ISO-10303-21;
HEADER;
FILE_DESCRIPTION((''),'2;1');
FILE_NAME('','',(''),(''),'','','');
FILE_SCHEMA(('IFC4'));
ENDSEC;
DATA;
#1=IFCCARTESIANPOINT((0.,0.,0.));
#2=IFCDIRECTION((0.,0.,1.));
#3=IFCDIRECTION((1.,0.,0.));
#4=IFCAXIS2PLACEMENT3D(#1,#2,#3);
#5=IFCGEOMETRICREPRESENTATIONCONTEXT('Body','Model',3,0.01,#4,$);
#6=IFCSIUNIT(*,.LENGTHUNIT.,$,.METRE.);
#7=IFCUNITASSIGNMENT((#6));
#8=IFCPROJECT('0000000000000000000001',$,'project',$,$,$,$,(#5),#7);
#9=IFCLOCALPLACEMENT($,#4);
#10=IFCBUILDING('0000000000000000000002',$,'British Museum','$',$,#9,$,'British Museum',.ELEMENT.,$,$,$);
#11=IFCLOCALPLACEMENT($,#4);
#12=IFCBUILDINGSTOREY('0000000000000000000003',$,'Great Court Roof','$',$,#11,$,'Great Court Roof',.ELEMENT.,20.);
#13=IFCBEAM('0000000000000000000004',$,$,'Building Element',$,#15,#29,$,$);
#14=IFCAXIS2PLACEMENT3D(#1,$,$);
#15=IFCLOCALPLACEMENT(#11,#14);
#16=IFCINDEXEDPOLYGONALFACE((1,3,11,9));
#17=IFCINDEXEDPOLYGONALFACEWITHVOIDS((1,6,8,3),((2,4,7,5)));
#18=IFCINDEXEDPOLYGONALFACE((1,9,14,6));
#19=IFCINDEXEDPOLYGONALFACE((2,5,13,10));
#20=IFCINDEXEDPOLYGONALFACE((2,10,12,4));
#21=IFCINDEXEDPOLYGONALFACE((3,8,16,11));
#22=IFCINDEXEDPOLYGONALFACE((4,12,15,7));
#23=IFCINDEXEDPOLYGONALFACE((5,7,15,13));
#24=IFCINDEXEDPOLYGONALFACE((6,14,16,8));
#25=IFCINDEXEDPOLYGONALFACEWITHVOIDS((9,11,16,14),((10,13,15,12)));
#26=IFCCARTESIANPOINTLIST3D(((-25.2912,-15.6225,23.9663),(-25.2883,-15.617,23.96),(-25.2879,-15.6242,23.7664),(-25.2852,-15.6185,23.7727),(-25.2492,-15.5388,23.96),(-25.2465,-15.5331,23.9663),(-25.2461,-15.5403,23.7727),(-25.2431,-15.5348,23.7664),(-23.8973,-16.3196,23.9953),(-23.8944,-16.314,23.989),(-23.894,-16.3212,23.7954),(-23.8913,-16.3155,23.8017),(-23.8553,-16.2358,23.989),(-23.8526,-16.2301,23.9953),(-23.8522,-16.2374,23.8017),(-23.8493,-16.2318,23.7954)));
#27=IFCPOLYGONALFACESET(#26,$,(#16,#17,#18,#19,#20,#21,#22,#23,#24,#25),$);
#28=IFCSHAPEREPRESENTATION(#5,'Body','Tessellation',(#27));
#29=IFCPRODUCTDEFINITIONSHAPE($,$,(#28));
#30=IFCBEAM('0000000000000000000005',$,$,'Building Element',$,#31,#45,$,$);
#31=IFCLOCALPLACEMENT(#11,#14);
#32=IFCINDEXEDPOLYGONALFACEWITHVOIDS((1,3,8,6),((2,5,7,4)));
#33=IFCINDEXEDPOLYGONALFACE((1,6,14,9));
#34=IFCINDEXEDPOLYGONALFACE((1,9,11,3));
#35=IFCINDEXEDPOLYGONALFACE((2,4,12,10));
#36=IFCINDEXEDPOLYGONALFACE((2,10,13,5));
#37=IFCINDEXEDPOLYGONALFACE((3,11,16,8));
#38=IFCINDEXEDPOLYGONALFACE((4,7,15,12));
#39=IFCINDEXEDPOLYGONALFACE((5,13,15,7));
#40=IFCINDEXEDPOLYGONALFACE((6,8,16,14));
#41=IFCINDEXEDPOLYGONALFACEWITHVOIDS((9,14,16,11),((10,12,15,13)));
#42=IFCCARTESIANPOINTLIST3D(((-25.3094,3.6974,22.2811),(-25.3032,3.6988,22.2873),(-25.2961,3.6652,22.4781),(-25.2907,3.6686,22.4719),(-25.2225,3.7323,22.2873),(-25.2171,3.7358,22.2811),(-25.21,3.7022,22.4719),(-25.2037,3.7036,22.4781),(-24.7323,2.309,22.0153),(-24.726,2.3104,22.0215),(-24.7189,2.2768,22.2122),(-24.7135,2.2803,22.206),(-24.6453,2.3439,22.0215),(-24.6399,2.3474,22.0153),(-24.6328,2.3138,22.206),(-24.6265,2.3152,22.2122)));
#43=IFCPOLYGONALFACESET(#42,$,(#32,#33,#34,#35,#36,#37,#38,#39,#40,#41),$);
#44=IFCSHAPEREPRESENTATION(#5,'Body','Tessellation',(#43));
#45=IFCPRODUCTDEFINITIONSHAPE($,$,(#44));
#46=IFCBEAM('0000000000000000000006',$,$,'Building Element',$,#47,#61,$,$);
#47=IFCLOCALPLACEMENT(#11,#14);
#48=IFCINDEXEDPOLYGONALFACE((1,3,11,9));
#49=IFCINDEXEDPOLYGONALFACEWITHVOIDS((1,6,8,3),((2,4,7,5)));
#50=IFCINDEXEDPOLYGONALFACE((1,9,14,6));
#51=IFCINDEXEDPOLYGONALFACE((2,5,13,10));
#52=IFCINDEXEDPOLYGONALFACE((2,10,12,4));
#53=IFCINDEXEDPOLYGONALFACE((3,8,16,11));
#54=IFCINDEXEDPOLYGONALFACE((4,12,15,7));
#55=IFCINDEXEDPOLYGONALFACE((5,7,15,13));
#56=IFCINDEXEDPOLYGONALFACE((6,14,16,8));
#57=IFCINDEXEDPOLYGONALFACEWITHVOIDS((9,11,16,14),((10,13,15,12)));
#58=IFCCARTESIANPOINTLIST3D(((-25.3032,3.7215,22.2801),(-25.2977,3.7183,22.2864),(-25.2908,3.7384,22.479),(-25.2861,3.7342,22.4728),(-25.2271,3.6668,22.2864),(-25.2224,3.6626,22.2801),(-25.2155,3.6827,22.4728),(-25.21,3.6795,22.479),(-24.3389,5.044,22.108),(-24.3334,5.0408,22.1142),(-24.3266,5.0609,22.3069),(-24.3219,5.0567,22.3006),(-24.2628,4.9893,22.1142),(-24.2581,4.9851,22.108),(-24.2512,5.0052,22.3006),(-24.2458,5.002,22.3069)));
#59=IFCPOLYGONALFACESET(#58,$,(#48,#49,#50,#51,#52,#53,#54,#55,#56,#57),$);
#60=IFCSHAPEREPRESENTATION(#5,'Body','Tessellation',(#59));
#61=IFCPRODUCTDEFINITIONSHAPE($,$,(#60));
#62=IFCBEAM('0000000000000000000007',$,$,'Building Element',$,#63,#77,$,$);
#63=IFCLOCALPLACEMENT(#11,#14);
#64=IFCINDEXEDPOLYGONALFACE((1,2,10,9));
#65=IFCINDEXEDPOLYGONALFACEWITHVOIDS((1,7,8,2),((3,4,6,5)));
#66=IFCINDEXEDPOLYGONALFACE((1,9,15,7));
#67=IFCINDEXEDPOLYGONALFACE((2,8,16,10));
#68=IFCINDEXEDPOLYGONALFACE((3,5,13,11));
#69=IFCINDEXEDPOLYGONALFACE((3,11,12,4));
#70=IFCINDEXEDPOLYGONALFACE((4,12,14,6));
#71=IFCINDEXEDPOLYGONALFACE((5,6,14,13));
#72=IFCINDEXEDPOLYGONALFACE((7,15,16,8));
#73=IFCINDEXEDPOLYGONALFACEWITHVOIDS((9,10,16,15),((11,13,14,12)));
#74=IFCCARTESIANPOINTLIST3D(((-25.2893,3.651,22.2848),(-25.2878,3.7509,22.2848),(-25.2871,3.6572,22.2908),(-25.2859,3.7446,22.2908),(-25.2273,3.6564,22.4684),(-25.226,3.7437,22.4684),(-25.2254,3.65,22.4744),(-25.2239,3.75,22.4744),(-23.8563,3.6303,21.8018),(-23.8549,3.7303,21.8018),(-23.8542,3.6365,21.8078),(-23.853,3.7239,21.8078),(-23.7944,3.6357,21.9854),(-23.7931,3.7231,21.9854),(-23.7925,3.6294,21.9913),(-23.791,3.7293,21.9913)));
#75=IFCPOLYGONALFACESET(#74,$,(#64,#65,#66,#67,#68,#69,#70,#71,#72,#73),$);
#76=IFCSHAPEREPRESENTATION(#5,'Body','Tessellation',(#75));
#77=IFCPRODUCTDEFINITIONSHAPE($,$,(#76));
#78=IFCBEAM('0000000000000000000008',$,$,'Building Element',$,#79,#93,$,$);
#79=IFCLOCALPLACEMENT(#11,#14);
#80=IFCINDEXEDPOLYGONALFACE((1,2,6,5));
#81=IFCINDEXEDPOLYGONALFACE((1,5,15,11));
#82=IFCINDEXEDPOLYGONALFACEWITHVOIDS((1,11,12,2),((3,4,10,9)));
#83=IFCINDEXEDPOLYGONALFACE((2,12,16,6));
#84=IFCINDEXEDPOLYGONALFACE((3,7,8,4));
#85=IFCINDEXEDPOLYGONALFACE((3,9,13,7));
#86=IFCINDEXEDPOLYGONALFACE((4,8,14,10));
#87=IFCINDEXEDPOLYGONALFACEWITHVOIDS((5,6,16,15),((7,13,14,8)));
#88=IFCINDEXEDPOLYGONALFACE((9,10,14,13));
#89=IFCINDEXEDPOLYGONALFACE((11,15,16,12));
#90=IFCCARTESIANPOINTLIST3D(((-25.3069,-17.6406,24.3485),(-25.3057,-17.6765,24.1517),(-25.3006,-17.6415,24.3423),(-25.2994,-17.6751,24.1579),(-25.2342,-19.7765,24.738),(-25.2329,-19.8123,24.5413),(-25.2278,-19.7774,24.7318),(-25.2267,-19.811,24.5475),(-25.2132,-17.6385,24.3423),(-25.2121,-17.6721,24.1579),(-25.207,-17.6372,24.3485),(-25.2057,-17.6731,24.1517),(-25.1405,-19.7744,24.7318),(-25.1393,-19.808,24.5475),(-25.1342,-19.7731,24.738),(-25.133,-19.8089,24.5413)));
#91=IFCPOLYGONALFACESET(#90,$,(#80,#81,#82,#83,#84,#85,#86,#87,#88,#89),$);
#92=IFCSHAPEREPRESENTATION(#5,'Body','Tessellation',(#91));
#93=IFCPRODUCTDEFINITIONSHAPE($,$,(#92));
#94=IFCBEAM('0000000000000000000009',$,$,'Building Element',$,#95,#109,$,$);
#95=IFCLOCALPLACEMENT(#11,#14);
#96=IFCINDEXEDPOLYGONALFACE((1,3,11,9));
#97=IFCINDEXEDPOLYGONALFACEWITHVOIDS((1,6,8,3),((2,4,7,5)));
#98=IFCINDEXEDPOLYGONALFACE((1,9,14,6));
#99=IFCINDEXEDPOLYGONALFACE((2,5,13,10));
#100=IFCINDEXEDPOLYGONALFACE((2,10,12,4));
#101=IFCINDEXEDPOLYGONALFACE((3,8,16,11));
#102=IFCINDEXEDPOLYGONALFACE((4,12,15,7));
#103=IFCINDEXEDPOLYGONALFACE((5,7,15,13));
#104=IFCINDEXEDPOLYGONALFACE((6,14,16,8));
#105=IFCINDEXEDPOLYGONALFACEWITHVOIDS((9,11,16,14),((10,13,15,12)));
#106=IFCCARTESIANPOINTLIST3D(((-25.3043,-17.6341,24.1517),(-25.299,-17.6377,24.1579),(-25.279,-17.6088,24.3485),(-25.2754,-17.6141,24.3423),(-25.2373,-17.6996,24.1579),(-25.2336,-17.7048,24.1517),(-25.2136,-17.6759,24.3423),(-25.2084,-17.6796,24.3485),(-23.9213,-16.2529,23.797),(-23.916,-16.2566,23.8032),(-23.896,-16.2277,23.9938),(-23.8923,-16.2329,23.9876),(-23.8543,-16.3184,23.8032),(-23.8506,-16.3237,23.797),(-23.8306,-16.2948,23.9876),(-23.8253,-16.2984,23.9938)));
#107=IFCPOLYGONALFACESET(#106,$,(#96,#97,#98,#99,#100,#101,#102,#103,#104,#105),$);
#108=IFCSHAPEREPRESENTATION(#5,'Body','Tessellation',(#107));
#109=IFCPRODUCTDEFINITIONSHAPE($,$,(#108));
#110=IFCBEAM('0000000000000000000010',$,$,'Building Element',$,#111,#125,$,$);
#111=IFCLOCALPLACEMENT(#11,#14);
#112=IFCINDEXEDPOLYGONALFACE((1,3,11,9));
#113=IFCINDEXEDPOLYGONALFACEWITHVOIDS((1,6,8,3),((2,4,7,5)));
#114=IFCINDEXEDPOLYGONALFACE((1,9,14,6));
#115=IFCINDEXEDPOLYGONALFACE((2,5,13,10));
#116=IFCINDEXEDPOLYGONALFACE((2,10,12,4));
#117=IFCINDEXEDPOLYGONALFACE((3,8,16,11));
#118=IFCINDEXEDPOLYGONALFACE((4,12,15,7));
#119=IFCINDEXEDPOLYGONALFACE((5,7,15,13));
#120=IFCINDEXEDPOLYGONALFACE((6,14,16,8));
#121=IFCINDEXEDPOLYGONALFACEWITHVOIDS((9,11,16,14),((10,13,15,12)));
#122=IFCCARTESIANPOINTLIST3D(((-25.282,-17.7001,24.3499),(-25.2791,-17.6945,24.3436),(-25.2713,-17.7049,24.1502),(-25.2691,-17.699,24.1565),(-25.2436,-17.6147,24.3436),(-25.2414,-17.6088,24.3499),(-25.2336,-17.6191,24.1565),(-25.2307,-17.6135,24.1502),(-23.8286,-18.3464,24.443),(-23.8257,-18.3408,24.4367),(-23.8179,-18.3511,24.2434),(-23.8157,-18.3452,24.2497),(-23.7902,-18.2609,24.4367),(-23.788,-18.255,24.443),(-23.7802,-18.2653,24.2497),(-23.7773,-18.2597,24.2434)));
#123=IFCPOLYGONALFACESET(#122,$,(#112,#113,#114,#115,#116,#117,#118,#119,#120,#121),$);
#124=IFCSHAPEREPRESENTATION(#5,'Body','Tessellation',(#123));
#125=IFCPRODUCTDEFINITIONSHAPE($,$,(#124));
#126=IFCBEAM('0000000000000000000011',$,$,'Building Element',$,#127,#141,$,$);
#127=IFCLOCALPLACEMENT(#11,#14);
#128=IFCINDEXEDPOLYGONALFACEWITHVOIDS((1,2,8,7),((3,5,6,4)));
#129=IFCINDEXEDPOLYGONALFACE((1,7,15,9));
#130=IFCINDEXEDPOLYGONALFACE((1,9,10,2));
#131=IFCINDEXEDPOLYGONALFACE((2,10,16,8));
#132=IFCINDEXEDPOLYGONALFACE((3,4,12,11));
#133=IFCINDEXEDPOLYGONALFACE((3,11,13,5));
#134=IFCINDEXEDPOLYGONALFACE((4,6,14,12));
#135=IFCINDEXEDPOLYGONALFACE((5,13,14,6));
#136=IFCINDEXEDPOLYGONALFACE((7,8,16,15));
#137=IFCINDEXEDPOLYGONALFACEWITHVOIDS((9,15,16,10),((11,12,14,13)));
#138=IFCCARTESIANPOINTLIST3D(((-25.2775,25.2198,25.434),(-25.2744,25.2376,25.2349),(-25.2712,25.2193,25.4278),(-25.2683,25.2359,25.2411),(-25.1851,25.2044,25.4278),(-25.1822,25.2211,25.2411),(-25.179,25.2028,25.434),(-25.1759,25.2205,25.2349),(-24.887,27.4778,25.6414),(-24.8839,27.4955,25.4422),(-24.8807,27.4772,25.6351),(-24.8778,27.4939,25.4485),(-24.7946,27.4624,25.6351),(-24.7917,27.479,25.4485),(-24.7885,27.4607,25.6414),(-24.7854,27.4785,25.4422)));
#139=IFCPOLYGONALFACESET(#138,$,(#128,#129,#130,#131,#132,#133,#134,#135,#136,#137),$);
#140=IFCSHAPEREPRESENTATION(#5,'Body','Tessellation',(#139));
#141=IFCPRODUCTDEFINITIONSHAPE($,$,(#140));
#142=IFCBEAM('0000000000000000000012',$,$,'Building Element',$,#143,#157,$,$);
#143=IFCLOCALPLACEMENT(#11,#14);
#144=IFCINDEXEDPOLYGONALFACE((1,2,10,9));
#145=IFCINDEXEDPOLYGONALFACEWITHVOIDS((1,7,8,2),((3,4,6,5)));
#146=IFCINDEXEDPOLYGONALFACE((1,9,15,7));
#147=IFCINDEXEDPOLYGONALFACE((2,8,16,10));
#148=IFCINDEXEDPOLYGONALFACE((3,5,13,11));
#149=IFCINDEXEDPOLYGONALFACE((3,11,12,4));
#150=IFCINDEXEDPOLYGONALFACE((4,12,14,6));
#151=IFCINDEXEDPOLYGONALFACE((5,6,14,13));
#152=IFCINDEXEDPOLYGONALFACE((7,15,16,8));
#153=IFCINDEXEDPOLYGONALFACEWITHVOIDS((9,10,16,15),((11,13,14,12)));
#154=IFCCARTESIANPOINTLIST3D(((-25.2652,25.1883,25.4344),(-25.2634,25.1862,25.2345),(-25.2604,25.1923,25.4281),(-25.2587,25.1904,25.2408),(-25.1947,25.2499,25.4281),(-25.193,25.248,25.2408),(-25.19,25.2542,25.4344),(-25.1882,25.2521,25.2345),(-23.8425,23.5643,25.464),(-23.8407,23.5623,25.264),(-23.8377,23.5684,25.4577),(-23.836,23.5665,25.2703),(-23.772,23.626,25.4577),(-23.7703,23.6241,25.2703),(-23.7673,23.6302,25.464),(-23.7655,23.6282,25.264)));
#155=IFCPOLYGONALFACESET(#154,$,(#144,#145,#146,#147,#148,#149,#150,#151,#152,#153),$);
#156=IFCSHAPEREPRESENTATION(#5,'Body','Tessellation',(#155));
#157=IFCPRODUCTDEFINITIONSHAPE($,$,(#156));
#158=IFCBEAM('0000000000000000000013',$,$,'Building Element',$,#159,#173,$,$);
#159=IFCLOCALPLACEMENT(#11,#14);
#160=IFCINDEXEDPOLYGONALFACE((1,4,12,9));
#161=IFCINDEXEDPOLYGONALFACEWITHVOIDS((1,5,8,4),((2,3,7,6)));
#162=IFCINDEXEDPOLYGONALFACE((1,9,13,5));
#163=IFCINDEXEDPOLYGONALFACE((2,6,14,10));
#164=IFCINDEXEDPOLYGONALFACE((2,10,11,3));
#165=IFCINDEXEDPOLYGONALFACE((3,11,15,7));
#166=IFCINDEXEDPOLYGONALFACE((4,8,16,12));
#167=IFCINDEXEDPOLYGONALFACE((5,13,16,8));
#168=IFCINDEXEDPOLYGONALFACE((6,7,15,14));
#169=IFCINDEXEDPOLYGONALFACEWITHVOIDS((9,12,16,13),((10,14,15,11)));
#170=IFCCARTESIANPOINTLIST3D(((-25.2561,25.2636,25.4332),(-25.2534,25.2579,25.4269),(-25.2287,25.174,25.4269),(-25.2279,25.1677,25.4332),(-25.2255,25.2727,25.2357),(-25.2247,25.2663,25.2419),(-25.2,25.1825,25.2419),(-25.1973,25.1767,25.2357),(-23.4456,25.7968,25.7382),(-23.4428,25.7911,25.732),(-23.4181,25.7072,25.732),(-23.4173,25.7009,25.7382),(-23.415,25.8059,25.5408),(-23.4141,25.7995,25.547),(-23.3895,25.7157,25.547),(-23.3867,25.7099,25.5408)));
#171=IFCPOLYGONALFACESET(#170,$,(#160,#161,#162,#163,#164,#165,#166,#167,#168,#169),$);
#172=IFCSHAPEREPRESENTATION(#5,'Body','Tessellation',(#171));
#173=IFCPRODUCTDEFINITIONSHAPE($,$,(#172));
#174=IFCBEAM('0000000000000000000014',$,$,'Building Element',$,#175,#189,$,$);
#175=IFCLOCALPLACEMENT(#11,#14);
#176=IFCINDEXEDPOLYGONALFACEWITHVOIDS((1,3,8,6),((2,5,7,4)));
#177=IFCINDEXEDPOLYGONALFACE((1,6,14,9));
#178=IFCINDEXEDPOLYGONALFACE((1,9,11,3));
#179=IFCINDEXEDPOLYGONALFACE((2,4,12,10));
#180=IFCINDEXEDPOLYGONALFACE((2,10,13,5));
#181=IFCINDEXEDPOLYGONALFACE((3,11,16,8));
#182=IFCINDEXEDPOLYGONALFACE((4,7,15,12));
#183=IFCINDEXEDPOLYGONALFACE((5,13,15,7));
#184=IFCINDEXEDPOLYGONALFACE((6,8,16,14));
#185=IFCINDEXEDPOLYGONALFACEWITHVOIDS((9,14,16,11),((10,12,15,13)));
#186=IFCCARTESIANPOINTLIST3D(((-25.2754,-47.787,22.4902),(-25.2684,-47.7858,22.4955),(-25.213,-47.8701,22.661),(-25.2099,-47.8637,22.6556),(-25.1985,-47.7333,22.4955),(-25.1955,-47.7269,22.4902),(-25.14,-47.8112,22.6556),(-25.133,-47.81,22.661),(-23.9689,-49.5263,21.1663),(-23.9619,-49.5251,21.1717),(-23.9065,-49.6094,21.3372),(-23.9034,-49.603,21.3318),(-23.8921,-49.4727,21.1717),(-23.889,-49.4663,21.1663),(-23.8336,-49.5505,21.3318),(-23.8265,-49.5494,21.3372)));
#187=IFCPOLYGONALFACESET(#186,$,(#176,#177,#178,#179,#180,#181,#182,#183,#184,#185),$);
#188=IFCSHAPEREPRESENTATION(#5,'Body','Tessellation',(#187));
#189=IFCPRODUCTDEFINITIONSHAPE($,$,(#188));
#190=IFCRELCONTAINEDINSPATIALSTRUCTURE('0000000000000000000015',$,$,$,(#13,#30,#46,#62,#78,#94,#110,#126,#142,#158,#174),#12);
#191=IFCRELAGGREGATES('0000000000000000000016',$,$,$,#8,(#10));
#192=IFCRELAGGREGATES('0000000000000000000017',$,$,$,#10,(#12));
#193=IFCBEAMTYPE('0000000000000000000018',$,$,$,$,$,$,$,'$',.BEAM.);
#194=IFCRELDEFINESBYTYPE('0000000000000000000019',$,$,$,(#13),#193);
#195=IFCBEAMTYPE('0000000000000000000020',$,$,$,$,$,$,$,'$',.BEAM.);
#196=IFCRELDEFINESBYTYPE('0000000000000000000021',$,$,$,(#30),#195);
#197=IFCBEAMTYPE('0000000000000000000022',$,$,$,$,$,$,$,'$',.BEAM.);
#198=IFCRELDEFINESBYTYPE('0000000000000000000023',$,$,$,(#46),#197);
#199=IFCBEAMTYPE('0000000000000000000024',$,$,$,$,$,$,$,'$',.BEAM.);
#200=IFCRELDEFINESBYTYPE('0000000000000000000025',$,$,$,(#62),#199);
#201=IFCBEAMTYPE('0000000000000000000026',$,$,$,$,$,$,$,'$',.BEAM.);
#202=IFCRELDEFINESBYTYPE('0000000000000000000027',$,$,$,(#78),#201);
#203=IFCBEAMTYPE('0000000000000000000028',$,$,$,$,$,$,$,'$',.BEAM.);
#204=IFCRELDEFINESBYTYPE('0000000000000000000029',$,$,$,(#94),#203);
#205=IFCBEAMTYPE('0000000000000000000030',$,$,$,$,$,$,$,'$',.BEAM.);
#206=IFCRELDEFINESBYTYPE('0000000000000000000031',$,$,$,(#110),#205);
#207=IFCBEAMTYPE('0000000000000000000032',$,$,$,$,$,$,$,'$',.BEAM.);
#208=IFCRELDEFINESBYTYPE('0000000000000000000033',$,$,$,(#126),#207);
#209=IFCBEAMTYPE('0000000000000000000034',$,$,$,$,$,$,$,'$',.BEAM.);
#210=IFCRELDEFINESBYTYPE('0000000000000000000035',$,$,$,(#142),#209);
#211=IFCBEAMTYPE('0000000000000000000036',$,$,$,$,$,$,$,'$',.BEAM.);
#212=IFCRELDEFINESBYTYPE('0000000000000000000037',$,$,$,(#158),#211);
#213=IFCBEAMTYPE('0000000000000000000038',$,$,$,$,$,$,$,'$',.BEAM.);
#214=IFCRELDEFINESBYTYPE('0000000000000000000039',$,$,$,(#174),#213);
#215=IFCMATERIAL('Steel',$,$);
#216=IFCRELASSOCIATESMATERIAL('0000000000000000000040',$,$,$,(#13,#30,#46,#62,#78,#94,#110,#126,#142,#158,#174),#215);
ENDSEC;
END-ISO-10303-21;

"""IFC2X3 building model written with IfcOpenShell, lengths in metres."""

from ifc_helpers import new_model, si_unit, frame, origin_with_axes, origin_2d, place, context, project, spatial, hollow_rectangle, extrude, material, type_object, element, save


model = new_model("IFC2X3")

# Units and contexts
model_context = context("Model", 3, precision=0.01, world=origin_with_axes(), identifier="Body")
ifc_project = project(units=[si_unit("LENGTHUNIT", "METRE")], contexts=[model_context])

# Building, storey
building_placement = place(None, origin_with_axes())
building = spatial("IfcBuilding", under=ifc_project, at=building_placement, Name="British Museum", Description="$", LongName="British Museum", CompositionType="ELEMENT")
storey_placement = place(None, origin_with_axes())
storey = spatial("IfcBuildingStorey", under=building, at=storey_placement, Name="Great Court Roof", Description="$", LongName="Great Court Roof", CompositionType="ELEMENT", Elevation=20.0)

# Beams
ifc_material = material(Name="Steel")
beam_type_1 = type_object("IfcBeamType", ElementType="$", PredefinedType="BEAM")
beam_1_placement = place(None, origin_with_axes())
element("IfcBeam", 1, at=beam_1_placement, inside=storey, type_object=beam_type_1, material=ifc_material, Description="Building Element", context=model_context, shape_type="SweptSolid", body=[
    extrude(hollow_rectangle(XDim=0.1, YDim=0.2, WallThickness=0.0063, InnerFilletRadius=-0.0063, OuterFilletRadius=0.0, at=origin_2d()), frame((-25.2672, -15.5787, 23.8664), z_axis=(0.894248, -0.447185, 0.018614), x_axis=(0.447262, 0.894403, 0.0)), (0.0, 0.0, 1.0), 1.5587),
])
beam_type_2 = type_object("IfcBeamType", ElementType="$", PredefinedType="BEAM")
beam_2_placement = place(None, origin_with_axes())
element("IfcBeam", 2, at=beam_2_placement, inside=storey, type_object=beam_type_2, material=ifc_material, Description="Building Element", context=model_context, shape_type="SweptSolid", body=[
    extrude(hollow_rectangle(XDim=0.1, YDim=0.2, WallThickness=0.0063, InnerFilletRadius=-0.0063, OuterFilletRadius=0.0, at=origin_2d()), frame((-25.2566, 3.7005, 22.3796), z_axis=(0.378015, -0.909282, -0.174099), x_axis=(0.923384, 0.383877, 0.0)), (0.0, 0.0, 1.0), 1.5269),
])
beam_type_3 = type_object("IfcBeamType", ElementType="$", PredefinedType="BEAM")
beam_3_placement = place(None, origin_with_axes())
element("IfcBeam", 3, at=beam_3_placement, inside=storey, type_object=beam_type_3, material=ifc_material, Description="Building Element", context=model_context, shape_type="SweptSolid", body=[
    extrude(hollow_rectangle(XDim=0.1, YDim=0.2, WallThickness=0.0063, InnerFilletRadius=-0.0063, OuterFilletRadius=0.0, at=origin_2d()), frame((-25.2566, 3.7005, 22.3796), z_axis=(0.585913, 0.803593, -0.104618), x_axis=(-0.808027, 0.589146, 0.0)), (0.0, 0.0, 1.0), 1.6458),
])
beam_type_4 = type_object("IfcBeamType", ElementType="$", PredefinedType="BEAM")
beam_4_placement = place(None, origin_with_axes())
element("IfcBeam", 4, at=beam_4_placement, inside=storey, type_object=beam_type_4, material=ifc_material, Description="Building Element", context=model_context, shape_type="SweptSolid", body=[
    extrude(hollow_rectangle(XDim=0.1, YDim=0.2, WallThickness=0.0063, InnerFilletRadius=-0.0063, OuterFilletRadius=0.0, at=origin_2d()), frame((-25.2566, 3.7005, 22.3796), z_axis=(0.947522, -0.013674, -0.319399), x_axis=(0.01443, 0.999896, 0.0)), (0.0, 0.0, 1.0), 1.5123),
])
beam_type_5 = type_object("IfcBeamType", ElementType="$", PredefinedType="BEAM")
beam_5_placement = place(None, origin_with_axes())
element("IfcBeam", 5, at=beam_5_placement, inside=storey, type_object=beam_type_5, material=ifc_material, Description="Building Element", context=model_context, shape_type="SweptSolid", body=[
    extrude(hollow_rectangle(XDim=0.1, YDim=0.2, WallThickness=0.0063, InnerFilletRadius=-0.0063, OuterFilletRadius=0.0, at=origin_2d()), frame((-25.2563, -17.6568, 24.2501), z_axis=(0.033492, -0.983217, 0.17934), x_axis=(0.99942, 0.034044, 0.0)), (0.0, 0.0, 1.0), 2.1723),
])
beam_type_6 = type_object("IfcBeamType", ElementType="$", PredefinedType="BEAM")
beam_6_placement = place(None, origin_with_axes())
element("IfcBeam", 6, at=beam_6_placement, inside=storey, type_object=beam_type_6, material=ifc_material, Description="Building Element", context=model_context, shape_type="SweptSolid", body=[
    extrude(hollow_rectangle(XDim=0.1, YDim=0.2, WallThickness=0.0063, InnerFilletRadius=-0.0063, OuterFilletRadius=0.0, at=origin_2d()), frame((-25.2563, -17.6568, 24.2501), z_axis=(0.696214, 0.695271, -0.178562), x_axis=(-0.706627, 0.707586, 0.0)), (0.0, 0.0, 1.0), 1.9865),
])
beam_type_7 = type_object("IfcBeamType", ElementType="$", PredefinedType="BEAM")
beam_7_placement = place(None, origin_with_axes())
element("IfcBeam", 7, at=beam_7_placement, inside=storey, type_object=beam_type_7, material=ifc_material, Description="Building Element", context=model_context, shape_type="SweptSolid", body=[
    extrude(hollow_rectangle(XDim=0.1, YDim=0.2, WallThickness=0.0063, InnerFilletRadius=-0.0063, OuterFilletRadius=0.0, at=origin_2d()), frame((-25.2563, -17.6568, 24.2501), z_axis=(0.912187, -0.405584, 0.058448), x_axis=(0.406279, 0.913749, 0.0)), (0.0, 0.0, 1.0), 1.5933),
])
beam_type_8 = type_object("IfcBeamType", ElementType="$", PredefinedType="BEAM")
beam_8_placement = place(None, origin_with_axes())
element("IfcBeam", 8, at=beam_8_placement, inside=storey, type_object=beam_type_8, material=ifc_material, Description="Building Element", context=model_context, shape_type="SweptSolid", body=[
    extrude(hollow_rectangle(XDim=0.1, YDim=0.2, WallThickness=0.0063, InnerFilletRadius=-0.0063, OuterFilletRadius=0.0, at=origin_2d()), frame((-25.2267, 25.2202, 25.3344), z_axis=(0.169718, 0.981364, 0.090112), x_axis=(-0.985373, 0.170412, 0.0)), (0.0, 0.0, 1.0), 2.3008),
])
beam_type_9 = type_object("IfcBeamType", ElementType="$", PredefinedType="BEAM")
beam_9_placement = place(None, origin_with_axes())
element("IfcBeam", 9, at=beam_9_placement, inside=storey, type_object=beam_type_9, material=ifc_material, Description="Building Element", context=model_context, shape_type="SweptSolid", body=[
    extrude(hollow_rectangle(XDim=0.1, YDim=0.2, WallThickness=0.0063, InnerFilletRadius=-0.0063, OuterFilletRadius=0.0, at=origin_2d()), frame((-25.2267, 25.2202, 25.3344), z_axis=(0.658893, -0.752112, 0.013676), x_axis=(0.752182, 0.658955, 0.0)), (0.0, 0.0, 1.0), 2.1592),
])
beam_type_10 = type_object("IfcBeamType", ElementType="$", PredefinedType="BEAM")
beam_10_placement = place(None, origin_with_axes())
element("IfcBeam", 10, at=beam_10_placement, inside=storey, type_object=beam_type_10, material=ifc_material, Description="Building Element", context=model_context, shape_type="SweptSolid", body=[
    extrude(hollow_rectangle(XDim=0.1, YDim=0.2, WallThickness=0.0063, InnerFilletRadius=-0.0063, OuterFilletRadius=0.0, at=origin_2d()), frame((-25.2267, 25.2202, 25.3344), z_axis=(0.946979, 0.278885, 0.159542), x_axis=(-0.282503, 0.959266, 0.0)), (0.0, 0.0, 1.0), 1.9119),
])
beam_type_11 = type_object("IfcBeamType", ElementType="$", PredefinedType="BEAM")
beam_11_placement = place(None, origin_with_axes())
element("IfcBeam", 11, at=beam_11_placement, inside=storey, type_object=beam_type_11, material=ifc_material, Description="Building Element", context=model_context, shape_type="SweptSolid", body=[
    extrude(hollow_rectangle(XDim=0.1, YDim=0.2, WallThickness=0.0063, InnerFilletRadius=-0.0063, OuterFilletRadius=0.0, at=origin_2d()), frame((-25.2042, -47.7985, 22.5756), z_axis=(0.513037, -0.68303, -0.519868), x_axis=(0.799571, 0.600572, 0.0)), (0.0, 0.0, 1.0), 2.5465),
])

save(model, "model.ifc")
